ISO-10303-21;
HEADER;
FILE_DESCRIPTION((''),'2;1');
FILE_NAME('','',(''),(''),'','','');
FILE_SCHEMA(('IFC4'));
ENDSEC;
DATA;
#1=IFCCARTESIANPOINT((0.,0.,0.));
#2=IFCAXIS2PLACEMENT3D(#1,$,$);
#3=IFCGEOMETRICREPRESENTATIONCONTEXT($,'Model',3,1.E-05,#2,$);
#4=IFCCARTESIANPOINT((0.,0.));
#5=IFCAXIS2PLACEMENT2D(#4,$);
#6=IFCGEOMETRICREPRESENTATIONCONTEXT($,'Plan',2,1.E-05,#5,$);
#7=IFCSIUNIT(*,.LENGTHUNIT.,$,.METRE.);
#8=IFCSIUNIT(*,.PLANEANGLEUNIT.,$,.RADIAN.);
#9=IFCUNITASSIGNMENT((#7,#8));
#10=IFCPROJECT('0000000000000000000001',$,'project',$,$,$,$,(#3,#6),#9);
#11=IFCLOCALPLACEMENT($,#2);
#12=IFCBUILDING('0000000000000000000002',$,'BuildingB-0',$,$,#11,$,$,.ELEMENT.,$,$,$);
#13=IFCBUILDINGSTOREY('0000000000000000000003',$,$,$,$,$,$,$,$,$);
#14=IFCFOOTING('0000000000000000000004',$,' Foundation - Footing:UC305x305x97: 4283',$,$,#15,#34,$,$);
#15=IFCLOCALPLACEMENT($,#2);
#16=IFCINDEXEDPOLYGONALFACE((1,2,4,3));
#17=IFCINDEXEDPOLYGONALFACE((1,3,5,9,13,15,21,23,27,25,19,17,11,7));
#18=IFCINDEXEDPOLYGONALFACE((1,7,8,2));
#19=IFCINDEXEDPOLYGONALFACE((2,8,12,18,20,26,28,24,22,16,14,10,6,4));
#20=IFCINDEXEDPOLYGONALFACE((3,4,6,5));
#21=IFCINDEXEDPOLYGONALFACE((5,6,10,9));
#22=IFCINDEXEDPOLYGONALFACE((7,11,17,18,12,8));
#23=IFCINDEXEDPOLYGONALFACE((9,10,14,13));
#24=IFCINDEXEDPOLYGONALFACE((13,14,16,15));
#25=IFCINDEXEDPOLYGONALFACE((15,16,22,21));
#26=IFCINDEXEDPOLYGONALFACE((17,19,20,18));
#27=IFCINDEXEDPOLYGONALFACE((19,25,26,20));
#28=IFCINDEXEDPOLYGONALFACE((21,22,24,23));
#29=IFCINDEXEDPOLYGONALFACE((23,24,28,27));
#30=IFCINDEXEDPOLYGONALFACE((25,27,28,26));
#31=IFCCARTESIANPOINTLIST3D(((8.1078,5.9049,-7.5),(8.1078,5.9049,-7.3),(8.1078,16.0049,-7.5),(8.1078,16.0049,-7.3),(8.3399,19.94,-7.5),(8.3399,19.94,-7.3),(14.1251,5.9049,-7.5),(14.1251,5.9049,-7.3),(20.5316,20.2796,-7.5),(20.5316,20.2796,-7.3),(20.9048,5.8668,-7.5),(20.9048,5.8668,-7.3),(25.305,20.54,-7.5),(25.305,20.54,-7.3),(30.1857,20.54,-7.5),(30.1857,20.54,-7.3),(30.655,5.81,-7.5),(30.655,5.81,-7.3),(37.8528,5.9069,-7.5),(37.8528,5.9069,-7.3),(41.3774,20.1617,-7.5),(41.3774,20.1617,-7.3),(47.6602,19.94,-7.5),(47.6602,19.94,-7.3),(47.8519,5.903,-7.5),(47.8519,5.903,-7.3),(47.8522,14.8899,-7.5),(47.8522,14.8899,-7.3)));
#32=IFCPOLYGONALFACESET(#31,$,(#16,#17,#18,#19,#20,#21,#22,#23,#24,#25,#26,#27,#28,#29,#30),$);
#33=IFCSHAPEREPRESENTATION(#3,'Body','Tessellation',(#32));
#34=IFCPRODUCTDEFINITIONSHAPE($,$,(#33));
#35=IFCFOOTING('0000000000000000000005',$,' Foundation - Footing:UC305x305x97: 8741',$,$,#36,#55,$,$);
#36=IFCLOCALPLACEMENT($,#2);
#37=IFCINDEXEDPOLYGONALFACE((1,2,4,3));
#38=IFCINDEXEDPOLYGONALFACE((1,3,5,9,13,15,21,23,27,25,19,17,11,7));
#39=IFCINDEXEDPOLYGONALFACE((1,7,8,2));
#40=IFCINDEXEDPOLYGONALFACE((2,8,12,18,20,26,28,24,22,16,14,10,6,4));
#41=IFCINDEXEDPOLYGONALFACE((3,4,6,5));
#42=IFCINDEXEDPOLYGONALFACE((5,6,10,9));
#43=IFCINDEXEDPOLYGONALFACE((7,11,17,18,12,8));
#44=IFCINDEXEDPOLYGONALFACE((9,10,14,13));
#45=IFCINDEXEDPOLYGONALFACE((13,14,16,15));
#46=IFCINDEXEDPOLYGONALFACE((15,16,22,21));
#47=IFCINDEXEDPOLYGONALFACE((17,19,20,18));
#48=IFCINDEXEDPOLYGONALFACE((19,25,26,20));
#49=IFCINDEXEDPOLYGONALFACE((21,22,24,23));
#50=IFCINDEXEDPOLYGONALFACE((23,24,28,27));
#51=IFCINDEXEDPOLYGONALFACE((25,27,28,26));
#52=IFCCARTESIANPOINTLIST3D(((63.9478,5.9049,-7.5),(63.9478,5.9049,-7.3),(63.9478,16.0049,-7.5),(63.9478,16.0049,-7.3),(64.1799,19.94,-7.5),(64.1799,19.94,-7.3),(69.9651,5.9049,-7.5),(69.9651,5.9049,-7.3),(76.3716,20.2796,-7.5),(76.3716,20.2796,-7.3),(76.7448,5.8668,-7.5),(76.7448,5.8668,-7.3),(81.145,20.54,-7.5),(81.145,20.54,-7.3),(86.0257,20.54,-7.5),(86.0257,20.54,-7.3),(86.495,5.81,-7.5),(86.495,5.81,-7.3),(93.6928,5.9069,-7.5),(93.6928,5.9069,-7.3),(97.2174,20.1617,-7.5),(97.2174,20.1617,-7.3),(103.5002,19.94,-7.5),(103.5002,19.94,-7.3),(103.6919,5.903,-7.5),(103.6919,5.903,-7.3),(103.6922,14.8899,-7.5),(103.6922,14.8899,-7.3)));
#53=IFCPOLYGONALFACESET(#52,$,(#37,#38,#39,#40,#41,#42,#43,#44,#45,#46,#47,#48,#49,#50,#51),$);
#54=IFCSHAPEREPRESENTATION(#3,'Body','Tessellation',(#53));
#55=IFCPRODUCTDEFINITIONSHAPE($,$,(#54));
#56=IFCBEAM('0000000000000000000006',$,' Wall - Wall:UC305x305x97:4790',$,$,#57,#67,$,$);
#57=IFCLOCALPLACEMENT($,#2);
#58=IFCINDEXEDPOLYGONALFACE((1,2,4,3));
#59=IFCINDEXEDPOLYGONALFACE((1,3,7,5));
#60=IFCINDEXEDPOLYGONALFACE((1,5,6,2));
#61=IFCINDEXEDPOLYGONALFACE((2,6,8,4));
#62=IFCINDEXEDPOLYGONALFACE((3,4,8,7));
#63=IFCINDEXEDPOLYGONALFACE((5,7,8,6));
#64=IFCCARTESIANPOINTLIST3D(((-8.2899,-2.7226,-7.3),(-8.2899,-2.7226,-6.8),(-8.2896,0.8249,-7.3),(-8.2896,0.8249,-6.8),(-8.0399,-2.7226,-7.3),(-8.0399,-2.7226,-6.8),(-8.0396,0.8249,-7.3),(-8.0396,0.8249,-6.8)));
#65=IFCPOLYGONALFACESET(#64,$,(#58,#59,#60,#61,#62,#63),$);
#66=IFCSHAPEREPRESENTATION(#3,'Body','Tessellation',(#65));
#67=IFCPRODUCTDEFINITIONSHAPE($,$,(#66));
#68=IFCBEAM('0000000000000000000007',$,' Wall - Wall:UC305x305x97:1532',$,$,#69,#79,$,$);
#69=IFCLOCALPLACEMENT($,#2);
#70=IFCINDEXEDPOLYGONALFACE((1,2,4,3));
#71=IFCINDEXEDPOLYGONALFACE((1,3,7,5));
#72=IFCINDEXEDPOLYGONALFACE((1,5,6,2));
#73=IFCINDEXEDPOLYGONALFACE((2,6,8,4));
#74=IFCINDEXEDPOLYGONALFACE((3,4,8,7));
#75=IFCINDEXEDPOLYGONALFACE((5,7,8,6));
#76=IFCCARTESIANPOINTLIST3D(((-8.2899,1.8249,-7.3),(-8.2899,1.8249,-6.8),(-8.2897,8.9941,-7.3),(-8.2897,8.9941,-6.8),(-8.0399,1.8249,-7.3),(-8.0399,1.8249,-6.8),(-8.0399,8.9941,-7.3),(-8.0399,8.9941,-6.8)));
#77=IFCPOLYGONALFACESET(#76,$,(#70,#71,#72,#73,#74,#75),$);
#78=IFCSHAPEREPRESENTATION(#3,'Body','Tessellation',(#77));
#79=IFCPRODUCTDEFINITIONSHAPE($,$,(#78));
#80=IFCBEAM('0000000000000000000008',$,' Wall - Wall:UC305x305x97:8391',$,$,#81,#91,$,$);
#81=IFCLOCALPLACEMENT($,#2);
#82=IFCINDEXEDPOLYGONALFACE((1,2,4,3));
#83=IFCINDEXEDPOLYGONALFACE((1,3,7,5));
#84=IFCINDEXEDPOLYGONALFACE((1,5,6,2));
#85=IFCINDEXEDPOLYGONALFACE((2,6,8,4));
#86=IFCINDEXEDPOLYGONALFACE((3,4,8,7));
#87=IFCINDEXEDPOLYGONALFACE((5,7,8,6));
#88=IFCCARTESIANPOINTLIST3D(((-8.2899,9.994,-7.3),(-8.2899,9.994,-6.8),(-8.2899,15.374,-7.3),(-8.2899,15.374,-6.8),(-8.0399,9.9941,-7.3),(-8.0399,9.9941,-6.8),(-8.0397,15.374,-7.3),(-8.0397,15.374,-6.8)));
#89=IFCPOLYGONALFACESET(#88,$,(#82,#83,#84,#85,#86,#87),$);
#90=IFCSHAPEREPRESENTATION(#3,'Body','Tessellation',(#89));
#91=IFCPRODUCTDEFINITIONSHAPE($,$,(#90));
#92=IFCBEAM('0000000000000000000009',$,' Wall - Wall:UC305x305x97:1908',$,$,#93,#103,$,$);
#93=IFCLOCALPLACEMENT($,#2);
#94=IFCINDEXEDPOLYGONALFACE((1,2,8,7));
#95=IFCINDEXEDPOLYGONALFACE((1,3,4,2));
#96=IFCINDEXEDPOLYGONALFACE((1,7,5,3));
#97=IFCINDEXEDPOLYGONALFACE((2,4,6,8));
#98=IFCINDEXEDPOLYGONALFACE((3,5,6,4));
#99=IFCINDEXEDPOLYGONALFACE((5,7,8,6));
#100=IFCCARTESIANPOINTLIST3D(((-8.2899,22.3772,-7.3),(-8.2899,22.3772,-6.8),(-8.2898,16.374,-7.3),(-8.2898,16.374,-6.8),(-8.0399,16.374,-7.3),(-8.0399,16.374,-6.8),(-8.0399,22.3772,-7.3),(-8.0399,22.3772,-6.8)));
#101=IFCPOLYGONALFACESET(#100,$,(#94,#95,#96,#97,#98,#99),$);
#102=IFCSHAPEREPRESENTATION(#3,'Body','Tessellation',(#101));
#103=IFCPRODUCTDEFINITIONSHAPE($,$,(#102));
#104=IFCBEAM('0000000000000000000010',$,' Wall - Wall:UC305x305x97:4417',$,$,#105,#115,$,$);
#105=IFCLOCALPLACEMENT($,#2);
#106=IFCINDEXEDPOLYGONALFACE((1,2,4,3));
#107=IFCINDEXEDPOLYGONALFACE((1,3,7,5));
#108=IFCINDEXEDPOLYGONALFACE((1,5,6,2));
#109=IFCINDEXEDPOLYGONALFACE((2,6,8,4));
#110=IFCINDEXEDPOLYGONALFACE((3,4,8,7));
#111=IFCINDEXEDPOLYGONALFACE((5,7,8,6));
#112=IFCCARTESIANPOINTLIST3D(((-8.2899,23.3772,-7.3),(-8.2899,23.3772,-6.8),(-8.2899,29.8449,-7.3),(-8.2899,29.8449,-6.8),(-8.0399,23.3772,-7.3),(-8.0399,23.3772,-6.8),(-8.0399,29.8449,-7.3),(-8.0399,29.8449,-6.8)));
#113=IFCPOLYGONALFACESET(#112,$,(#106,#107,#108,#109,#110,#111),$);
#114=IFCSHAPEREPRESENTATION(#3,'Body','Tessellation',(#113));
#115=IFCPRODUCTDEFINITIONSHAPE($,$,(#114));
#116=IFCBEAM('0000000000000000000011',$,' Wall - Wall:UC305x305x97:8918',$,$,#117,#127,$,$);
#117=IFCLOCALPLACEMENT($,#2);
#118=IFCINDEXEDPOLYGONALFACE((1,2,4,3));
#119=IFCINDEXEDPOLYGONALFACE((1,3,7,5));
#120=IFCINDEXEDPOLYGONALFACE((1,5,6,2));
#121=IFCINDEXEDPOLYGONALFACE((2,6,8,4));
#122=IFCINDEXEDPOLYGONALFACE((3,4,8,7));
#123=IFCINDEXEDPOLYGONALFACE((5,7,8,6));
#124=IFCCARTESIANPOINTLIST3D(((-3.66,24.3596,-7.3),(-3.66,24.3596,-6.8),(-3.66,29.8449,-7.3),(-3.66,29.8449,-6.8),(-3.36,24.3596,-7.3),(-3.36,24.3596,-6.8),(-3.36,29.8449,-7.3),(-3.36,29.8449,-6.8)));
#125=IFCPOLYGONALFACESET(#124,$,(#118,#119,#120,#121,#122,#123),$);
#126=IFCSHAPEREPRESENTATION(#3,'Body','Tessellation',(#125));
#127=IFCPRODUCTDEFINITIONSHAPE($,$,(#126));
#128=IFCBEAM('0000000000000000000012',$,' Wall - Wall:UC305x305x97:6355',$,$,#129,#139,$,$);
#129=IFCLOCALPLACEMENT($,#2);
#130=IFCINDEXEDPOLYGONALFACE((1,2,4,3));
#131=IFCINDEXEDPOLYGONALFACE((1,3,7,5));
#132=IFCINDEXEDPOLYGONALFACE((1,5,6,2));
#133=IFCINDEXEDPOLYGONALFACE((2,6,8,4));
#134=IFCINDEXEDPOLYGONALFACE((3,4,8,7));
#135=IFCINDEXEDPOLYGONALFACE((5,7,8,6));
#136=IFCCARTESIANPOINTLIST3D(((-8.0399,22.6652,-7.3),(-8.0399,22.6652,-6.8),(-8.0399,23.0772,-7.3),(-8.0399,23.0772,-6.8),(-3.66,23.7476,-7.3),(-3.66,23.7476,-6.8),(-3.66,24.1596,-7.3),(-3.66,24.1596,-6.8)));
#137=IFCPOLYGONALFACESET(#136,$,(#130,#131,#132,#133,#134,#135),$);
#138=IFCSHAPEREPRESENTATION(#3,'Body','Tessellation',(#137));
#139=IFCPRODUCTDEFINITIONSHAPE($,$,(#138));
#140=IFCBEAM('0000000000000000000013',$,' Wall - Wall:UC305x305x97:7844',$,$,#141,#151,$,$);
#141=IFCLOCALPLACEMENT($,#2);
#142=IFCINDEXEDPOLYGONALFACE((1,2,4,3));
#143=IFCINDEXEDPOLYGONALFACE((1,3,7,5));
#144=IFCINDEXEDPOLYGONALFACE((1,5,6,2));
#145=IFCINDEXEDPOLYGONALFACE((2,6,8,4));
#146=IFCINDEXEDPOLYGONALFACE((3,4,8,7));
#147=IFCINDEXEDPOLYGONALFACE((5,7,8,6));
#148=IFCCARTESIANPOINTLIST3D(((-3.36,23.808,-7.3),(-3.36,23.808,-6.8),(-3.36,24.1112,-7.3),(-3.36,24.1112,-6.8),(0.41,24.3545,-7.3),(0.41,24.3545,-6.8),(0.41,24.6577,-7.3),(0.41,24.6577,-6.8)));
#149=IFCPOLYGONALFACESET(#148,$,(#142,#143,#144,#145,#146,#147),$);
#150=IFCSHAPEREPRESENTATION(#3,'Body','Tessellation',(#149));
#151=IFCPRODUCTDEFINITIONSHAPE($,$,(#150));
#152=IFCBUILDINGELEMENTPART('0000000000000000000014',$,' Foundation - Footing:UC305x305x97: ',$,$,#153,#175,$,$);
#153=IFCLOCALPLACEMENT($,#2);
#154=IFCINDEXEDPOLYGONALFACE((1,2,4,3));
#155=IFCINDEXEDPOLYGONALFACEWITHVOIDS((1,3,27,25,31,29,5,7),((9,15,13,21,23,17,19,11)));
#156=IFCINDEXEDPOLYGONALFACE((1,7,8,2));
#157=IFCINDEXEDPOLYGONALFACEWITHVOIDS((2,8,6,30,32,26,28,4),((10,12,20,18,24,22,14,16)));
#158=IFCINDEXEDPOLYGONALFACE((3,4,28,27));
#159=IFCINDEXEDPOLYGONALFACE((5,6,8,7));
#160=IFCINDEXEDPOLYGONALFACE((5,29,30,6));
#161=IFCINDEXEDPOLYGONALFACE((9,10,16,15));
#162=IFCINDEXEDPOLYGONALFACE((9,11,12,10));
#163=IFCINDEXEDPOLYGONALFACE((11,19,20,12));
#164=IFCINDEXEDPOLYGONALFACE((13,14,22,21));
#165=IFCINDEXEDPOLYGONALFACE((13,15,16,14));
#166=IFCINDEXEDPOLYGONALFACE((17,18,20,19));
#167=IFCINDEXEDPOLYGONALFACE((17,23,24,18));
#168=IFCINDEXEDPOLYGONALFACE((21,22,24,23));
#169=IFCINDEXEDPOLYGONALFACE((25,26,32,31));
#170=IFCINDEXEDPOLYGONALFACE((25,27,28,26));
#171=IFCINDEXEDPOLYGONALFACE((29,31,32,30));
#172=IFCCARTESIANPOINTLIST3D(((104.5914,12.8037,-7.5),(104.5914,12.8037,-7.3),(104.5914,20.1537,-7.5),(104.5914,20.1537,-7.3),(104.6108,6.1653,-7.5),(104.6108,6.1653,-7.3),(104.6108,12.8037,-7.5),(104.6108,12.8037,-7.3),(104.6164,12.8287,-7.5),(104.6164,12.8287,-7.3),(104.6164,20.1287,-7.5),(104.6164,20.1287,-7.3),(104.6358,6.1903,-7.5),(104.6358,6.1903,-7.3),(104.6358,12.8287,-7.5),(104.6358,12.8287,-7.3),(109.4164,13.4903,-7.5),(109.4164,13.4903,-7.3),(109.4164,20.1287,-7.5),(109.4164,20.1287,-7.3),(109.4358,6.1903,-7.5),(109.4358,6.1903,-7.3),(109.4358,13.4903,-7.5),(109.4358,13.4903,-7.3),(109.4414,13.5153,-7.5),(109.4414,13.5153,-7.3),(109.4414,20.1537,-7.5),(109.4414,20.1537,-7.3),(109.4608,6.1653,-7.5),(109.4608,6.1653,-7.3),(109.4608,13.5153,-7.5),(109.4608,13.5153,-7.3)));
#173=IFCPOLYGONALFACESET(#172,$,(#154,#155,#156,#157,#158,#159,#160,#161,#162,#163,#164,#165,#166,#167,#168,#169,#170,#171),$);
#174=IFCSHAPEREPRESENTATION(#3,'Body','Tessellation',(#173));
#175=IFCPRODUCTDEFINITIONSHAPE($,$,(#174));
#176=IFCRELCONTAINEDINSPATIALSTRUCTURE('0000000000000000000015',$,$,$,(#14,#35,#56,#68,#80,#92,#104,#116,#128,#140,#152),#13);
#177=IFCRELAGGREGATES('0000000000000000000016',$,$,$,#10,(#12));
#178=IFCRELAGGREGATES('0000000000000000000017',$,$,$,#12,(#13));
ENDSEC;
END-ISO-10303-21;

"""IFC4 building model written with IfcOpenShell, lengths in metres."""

from ifc_helpers import new_model, si_unit, origin, origin_2d, place, context, project, spatial, polyline, outline, extrude, element, save


model = new_model("IFC4")

# Units and contexts
model_context = context("Model", 3, precision=1e-05, world=origin())
plan_context = context("Plan", 2, precision=1e-05, world=origin_2d())
ifc_project = project(units=[si_unit("LENGTHUNIT", "METRE"), si_unit("PLANEANGLEUNIT", "RADIAN")], contexts=[model_context, plan_context])

# Building, storey
building_placement = place(None, origin())
building = spatial("IfcBuilding", under=ifc_project, at=building_placement, Name="BuildingB-0", CompositionType="ELEMENT")
storey = spatial("IfcBuildingStorey", under=building)

# Footings
element("IfcFooting", 1, inside=storey, Name=" Foundation - Footing:UC305x305x97: 4283", context=model_context, shape_type="SweptSolid", body=[
    extrude(outline(polyline([(8.3399, 19.94, -7.5), (20.5316, 20.2796, -7.5), (25.305, 20.54, -7.5), (30.1857, 20.54, -7.5), (41.3774, 20.1617, -7.5), (47.6602, 19.94, -7.5), (47.8522, 14.8899, -7.5), (47.8519, 5.903, -7.5), (37.8528, 5.9069, -7.5), (30.655, 5.81, -7.5), (20.9048, 5.8668, -7.5), (14.1251, 5.9049, -7.5), (8.1078, 5.9049, -7.5), (8.1078, 16.0049, -7.5), (8.3399, 19.94, -7.5)])), None, (0.0, 0.0, 1.0), 0.2),
])
element("IfcFooting", 2, inside=storey, Name=" Foundation - Footing:UC305x305x97: 8741", context=model_context, shape_type="SweptSolid", body=[
    extrude(outline(polyline([(64.1799, 19.94, -7.5), (76.3716, 20.2796, -7.5), (81.145, 20.54, -7.5), (86.0257, 20.54, -7.5), (97.2174, 20.1617, -7.5), (103.5002, 19.94, -7.5), (103.6922, 14.8899, -7.5), (103.6919, 5.903, -7.5), (93.6928, 5.9069, -7.5), (86.495, 5.81, -7.5), (76.7448, 5.8668, -7.5), (69.9651, 5.9049, -7.5), (63.9478, 5.9049, -7.5), (63.9478, 16.0049, -7.5), (64.1799, 19.94, -7.5)])), None, (0.0, 0.0, 1.0), 0.2),
])

# Beams
element("IfcBeam", 3, inside=storey, Name=" Wall - Wall:UC305x305x97:4790", context=model_context, shape_type="SweptSolid", body=[
    extrude(outline(polyline([(-8.2899, -2.7226, -7.3), (-8.0399, -2.7226, -7.3), (-8.0396, 0.8249, -7.3), (-8.2896, 0.8249, -7.3), (-8.2899, -2.7226, -7.3)])), None, (0.0, 0.0, 1.0), 0.5),
])
element("IfcBeam", 4, inside=storey, Name=" Wall - Wall:UC305x305x97:1532", context=model_context, shape_type="SweptSolid", body=[
    extrude(outline(polyline([(-8.2899, 1.8249, -7.3), (-8.0399, 1.8249, -7.3), (-8.0399, 8.9941, -7.3), (-8.2897, 8.9941, -7.3), (-8.2899, 1.8249, -7.3)])), None, (0.0, 0.0, 1.0), 0.5),
])
element("IfcBeam", 5, inside=storey, Name=" Wall - Wall:UC305x305x97:8391", context=model_context, shape_type="SweptSolid", body=[
    extrude(outline(polyline([(-8.2899, 9.994, -7.3), (-8.0399, 9.9941, -7.3), (-8.0397, 15.374, -7.3), (-8.2899, 15.374, -7.3), (-8.2899, 9.994, -7.3)])), None, (0.0, 0.0, 1.0), 0.5),
])
element("IfcBeam", 6, inside=storey, Name=" Wall - Wall:UC305x305x97:1908", context=model_context, shape_type="SweptSolid", body=[
    extrude(outline(polyline([(-8.2898, 16.374, -7.3), (-8.0399, 16.374, -7.3), (-8.0399, 22.3772, -7.3), (-8.2899, 22.3772, -7.3), (-8.2898, 16.374, -7.3)])), None, (0.0, 0.0, 1.0), 0.5),
])
element("IfcBeam", 7, inside=storey, Name=" Wall - Wall:UC305x305x97:4417", context=model_context, shape_type="SweptSolid", body=[
    extrude(outline(polyline([(-8.2899, 23.3772, -7.3), (-8.0399, 23.3772, -7.3), (-8.0399, 29.8449, -7.3), (-8.2899, 29.8449, -7.3), (-8.2899, 23.3772, -7.3)])), None, (0.0, 0.0, 1.0), 0.5),
])
element("IfcBeam", 8, inside=storey, Name=" Wall - Wall:UC305x305x97:8918", context=model_context, shape_type="SweptSolid", body=[
    extrude(outline(polyline([(-3.66, 29.8449, -7.3), (-3.36, 29.8449, -7.3), (-3.36, 24.3596, -7.3), (-3.66, 24.3596, -7.3), (-3.66, 29.8449, -7.3)])), None, (0.0, 0.0, 1.0), 0.5),
])
element("IfcBeam", 9, inside=storey, Name=" Wall - Wall:UC305x305x97:6355", context=model_context, shape_type="SweptSolid", body=[
    extrude(outline(polyline([(-3.66, 24.1596, -7.3), (-3.66, 23.7476, -7.3), (-8.0399, 22.6652, -7.3), (-8.0399, 23.0772, -7.3), (-3.66, 24.1596, -7.3)])), None, (0.0, 0.0, 1.0), 0.5),
])
element("IfcBeam", 10, inside=storey, Name=" Wall - Wall:UC305x305x97:7844", context=model_context, shape_type="SweptSolid", body=[
    extrude(outline(polyline([(-3.36, 23.808, -7.3), (0.41, 24.3545, -7.3), (0.41, 24.6577, -7.3), (-3.36, 24.1112, -7.3), (-3.36, 23.808, -7.3)])), None, (0.0, 0.0, 1.0), 0.5),
])

# Building element part, opening
building_element_part_1 = element("IfcBuildingElementPart", 11, inside=storey, Name=" Foundation - Footing:UC305x305x97: ", context=model_context, shape_type="SweptSolid", body=[
    extrude(outline(polyline([(104.6108, 12.8037, -7.5), (104.5914, 12.8037, -7.5), (104.5914, 15.1899, -7.5), (104.5914, 20.1537, -7.5), (109.4414, 20.1537, -7.5), (109.4414, 17.04, -7.5), (109.4414, 13.5153, -7.5), (109.4608, 13.5153, -7.5), (109.4608, 9.16, -7.5), (109.4608, 6.1653, -7.5), (106.4755, 6.1653, -7.5), (104.6108, 6.1653, -7.5), (104.6108, 9.3099, -7.5), (104.6108, 12.8037, -7.5)])), None, (0.0, 0.0, 1.0), 0.2),
])
element("IfcOpeningElement", 12, inside=storey, cuts=building_element_part_1, context=model_context, shape_type="SweptSolid", body=[
    extrude(outline(polyline([(104.6358, 12.8287, -7.5), (104.6164, 12.8287, -7.5), (104.6164, 15.1899, -7.5), (104.6164, 20.1287, -7.5), (109.4164, 20.1287, -7.5), (109.4164, 17.04, -7.5), (109.4164, 13.4903, -7.5), (109.4358, 13.4903, -7.5), (109.4358, 9.16, -7.5), (109.4358, 6.1903, -7.5), (106.4755, 6.1903, -7.5), (104.6358, 6.1903, -7.5), (104.6358, 9.3099, -7.5), (104.6358, 12.8287, -7.5)])), None, (0.0, 0.0, 1.0), 0.2),
])

save(model, "model.ifc")
